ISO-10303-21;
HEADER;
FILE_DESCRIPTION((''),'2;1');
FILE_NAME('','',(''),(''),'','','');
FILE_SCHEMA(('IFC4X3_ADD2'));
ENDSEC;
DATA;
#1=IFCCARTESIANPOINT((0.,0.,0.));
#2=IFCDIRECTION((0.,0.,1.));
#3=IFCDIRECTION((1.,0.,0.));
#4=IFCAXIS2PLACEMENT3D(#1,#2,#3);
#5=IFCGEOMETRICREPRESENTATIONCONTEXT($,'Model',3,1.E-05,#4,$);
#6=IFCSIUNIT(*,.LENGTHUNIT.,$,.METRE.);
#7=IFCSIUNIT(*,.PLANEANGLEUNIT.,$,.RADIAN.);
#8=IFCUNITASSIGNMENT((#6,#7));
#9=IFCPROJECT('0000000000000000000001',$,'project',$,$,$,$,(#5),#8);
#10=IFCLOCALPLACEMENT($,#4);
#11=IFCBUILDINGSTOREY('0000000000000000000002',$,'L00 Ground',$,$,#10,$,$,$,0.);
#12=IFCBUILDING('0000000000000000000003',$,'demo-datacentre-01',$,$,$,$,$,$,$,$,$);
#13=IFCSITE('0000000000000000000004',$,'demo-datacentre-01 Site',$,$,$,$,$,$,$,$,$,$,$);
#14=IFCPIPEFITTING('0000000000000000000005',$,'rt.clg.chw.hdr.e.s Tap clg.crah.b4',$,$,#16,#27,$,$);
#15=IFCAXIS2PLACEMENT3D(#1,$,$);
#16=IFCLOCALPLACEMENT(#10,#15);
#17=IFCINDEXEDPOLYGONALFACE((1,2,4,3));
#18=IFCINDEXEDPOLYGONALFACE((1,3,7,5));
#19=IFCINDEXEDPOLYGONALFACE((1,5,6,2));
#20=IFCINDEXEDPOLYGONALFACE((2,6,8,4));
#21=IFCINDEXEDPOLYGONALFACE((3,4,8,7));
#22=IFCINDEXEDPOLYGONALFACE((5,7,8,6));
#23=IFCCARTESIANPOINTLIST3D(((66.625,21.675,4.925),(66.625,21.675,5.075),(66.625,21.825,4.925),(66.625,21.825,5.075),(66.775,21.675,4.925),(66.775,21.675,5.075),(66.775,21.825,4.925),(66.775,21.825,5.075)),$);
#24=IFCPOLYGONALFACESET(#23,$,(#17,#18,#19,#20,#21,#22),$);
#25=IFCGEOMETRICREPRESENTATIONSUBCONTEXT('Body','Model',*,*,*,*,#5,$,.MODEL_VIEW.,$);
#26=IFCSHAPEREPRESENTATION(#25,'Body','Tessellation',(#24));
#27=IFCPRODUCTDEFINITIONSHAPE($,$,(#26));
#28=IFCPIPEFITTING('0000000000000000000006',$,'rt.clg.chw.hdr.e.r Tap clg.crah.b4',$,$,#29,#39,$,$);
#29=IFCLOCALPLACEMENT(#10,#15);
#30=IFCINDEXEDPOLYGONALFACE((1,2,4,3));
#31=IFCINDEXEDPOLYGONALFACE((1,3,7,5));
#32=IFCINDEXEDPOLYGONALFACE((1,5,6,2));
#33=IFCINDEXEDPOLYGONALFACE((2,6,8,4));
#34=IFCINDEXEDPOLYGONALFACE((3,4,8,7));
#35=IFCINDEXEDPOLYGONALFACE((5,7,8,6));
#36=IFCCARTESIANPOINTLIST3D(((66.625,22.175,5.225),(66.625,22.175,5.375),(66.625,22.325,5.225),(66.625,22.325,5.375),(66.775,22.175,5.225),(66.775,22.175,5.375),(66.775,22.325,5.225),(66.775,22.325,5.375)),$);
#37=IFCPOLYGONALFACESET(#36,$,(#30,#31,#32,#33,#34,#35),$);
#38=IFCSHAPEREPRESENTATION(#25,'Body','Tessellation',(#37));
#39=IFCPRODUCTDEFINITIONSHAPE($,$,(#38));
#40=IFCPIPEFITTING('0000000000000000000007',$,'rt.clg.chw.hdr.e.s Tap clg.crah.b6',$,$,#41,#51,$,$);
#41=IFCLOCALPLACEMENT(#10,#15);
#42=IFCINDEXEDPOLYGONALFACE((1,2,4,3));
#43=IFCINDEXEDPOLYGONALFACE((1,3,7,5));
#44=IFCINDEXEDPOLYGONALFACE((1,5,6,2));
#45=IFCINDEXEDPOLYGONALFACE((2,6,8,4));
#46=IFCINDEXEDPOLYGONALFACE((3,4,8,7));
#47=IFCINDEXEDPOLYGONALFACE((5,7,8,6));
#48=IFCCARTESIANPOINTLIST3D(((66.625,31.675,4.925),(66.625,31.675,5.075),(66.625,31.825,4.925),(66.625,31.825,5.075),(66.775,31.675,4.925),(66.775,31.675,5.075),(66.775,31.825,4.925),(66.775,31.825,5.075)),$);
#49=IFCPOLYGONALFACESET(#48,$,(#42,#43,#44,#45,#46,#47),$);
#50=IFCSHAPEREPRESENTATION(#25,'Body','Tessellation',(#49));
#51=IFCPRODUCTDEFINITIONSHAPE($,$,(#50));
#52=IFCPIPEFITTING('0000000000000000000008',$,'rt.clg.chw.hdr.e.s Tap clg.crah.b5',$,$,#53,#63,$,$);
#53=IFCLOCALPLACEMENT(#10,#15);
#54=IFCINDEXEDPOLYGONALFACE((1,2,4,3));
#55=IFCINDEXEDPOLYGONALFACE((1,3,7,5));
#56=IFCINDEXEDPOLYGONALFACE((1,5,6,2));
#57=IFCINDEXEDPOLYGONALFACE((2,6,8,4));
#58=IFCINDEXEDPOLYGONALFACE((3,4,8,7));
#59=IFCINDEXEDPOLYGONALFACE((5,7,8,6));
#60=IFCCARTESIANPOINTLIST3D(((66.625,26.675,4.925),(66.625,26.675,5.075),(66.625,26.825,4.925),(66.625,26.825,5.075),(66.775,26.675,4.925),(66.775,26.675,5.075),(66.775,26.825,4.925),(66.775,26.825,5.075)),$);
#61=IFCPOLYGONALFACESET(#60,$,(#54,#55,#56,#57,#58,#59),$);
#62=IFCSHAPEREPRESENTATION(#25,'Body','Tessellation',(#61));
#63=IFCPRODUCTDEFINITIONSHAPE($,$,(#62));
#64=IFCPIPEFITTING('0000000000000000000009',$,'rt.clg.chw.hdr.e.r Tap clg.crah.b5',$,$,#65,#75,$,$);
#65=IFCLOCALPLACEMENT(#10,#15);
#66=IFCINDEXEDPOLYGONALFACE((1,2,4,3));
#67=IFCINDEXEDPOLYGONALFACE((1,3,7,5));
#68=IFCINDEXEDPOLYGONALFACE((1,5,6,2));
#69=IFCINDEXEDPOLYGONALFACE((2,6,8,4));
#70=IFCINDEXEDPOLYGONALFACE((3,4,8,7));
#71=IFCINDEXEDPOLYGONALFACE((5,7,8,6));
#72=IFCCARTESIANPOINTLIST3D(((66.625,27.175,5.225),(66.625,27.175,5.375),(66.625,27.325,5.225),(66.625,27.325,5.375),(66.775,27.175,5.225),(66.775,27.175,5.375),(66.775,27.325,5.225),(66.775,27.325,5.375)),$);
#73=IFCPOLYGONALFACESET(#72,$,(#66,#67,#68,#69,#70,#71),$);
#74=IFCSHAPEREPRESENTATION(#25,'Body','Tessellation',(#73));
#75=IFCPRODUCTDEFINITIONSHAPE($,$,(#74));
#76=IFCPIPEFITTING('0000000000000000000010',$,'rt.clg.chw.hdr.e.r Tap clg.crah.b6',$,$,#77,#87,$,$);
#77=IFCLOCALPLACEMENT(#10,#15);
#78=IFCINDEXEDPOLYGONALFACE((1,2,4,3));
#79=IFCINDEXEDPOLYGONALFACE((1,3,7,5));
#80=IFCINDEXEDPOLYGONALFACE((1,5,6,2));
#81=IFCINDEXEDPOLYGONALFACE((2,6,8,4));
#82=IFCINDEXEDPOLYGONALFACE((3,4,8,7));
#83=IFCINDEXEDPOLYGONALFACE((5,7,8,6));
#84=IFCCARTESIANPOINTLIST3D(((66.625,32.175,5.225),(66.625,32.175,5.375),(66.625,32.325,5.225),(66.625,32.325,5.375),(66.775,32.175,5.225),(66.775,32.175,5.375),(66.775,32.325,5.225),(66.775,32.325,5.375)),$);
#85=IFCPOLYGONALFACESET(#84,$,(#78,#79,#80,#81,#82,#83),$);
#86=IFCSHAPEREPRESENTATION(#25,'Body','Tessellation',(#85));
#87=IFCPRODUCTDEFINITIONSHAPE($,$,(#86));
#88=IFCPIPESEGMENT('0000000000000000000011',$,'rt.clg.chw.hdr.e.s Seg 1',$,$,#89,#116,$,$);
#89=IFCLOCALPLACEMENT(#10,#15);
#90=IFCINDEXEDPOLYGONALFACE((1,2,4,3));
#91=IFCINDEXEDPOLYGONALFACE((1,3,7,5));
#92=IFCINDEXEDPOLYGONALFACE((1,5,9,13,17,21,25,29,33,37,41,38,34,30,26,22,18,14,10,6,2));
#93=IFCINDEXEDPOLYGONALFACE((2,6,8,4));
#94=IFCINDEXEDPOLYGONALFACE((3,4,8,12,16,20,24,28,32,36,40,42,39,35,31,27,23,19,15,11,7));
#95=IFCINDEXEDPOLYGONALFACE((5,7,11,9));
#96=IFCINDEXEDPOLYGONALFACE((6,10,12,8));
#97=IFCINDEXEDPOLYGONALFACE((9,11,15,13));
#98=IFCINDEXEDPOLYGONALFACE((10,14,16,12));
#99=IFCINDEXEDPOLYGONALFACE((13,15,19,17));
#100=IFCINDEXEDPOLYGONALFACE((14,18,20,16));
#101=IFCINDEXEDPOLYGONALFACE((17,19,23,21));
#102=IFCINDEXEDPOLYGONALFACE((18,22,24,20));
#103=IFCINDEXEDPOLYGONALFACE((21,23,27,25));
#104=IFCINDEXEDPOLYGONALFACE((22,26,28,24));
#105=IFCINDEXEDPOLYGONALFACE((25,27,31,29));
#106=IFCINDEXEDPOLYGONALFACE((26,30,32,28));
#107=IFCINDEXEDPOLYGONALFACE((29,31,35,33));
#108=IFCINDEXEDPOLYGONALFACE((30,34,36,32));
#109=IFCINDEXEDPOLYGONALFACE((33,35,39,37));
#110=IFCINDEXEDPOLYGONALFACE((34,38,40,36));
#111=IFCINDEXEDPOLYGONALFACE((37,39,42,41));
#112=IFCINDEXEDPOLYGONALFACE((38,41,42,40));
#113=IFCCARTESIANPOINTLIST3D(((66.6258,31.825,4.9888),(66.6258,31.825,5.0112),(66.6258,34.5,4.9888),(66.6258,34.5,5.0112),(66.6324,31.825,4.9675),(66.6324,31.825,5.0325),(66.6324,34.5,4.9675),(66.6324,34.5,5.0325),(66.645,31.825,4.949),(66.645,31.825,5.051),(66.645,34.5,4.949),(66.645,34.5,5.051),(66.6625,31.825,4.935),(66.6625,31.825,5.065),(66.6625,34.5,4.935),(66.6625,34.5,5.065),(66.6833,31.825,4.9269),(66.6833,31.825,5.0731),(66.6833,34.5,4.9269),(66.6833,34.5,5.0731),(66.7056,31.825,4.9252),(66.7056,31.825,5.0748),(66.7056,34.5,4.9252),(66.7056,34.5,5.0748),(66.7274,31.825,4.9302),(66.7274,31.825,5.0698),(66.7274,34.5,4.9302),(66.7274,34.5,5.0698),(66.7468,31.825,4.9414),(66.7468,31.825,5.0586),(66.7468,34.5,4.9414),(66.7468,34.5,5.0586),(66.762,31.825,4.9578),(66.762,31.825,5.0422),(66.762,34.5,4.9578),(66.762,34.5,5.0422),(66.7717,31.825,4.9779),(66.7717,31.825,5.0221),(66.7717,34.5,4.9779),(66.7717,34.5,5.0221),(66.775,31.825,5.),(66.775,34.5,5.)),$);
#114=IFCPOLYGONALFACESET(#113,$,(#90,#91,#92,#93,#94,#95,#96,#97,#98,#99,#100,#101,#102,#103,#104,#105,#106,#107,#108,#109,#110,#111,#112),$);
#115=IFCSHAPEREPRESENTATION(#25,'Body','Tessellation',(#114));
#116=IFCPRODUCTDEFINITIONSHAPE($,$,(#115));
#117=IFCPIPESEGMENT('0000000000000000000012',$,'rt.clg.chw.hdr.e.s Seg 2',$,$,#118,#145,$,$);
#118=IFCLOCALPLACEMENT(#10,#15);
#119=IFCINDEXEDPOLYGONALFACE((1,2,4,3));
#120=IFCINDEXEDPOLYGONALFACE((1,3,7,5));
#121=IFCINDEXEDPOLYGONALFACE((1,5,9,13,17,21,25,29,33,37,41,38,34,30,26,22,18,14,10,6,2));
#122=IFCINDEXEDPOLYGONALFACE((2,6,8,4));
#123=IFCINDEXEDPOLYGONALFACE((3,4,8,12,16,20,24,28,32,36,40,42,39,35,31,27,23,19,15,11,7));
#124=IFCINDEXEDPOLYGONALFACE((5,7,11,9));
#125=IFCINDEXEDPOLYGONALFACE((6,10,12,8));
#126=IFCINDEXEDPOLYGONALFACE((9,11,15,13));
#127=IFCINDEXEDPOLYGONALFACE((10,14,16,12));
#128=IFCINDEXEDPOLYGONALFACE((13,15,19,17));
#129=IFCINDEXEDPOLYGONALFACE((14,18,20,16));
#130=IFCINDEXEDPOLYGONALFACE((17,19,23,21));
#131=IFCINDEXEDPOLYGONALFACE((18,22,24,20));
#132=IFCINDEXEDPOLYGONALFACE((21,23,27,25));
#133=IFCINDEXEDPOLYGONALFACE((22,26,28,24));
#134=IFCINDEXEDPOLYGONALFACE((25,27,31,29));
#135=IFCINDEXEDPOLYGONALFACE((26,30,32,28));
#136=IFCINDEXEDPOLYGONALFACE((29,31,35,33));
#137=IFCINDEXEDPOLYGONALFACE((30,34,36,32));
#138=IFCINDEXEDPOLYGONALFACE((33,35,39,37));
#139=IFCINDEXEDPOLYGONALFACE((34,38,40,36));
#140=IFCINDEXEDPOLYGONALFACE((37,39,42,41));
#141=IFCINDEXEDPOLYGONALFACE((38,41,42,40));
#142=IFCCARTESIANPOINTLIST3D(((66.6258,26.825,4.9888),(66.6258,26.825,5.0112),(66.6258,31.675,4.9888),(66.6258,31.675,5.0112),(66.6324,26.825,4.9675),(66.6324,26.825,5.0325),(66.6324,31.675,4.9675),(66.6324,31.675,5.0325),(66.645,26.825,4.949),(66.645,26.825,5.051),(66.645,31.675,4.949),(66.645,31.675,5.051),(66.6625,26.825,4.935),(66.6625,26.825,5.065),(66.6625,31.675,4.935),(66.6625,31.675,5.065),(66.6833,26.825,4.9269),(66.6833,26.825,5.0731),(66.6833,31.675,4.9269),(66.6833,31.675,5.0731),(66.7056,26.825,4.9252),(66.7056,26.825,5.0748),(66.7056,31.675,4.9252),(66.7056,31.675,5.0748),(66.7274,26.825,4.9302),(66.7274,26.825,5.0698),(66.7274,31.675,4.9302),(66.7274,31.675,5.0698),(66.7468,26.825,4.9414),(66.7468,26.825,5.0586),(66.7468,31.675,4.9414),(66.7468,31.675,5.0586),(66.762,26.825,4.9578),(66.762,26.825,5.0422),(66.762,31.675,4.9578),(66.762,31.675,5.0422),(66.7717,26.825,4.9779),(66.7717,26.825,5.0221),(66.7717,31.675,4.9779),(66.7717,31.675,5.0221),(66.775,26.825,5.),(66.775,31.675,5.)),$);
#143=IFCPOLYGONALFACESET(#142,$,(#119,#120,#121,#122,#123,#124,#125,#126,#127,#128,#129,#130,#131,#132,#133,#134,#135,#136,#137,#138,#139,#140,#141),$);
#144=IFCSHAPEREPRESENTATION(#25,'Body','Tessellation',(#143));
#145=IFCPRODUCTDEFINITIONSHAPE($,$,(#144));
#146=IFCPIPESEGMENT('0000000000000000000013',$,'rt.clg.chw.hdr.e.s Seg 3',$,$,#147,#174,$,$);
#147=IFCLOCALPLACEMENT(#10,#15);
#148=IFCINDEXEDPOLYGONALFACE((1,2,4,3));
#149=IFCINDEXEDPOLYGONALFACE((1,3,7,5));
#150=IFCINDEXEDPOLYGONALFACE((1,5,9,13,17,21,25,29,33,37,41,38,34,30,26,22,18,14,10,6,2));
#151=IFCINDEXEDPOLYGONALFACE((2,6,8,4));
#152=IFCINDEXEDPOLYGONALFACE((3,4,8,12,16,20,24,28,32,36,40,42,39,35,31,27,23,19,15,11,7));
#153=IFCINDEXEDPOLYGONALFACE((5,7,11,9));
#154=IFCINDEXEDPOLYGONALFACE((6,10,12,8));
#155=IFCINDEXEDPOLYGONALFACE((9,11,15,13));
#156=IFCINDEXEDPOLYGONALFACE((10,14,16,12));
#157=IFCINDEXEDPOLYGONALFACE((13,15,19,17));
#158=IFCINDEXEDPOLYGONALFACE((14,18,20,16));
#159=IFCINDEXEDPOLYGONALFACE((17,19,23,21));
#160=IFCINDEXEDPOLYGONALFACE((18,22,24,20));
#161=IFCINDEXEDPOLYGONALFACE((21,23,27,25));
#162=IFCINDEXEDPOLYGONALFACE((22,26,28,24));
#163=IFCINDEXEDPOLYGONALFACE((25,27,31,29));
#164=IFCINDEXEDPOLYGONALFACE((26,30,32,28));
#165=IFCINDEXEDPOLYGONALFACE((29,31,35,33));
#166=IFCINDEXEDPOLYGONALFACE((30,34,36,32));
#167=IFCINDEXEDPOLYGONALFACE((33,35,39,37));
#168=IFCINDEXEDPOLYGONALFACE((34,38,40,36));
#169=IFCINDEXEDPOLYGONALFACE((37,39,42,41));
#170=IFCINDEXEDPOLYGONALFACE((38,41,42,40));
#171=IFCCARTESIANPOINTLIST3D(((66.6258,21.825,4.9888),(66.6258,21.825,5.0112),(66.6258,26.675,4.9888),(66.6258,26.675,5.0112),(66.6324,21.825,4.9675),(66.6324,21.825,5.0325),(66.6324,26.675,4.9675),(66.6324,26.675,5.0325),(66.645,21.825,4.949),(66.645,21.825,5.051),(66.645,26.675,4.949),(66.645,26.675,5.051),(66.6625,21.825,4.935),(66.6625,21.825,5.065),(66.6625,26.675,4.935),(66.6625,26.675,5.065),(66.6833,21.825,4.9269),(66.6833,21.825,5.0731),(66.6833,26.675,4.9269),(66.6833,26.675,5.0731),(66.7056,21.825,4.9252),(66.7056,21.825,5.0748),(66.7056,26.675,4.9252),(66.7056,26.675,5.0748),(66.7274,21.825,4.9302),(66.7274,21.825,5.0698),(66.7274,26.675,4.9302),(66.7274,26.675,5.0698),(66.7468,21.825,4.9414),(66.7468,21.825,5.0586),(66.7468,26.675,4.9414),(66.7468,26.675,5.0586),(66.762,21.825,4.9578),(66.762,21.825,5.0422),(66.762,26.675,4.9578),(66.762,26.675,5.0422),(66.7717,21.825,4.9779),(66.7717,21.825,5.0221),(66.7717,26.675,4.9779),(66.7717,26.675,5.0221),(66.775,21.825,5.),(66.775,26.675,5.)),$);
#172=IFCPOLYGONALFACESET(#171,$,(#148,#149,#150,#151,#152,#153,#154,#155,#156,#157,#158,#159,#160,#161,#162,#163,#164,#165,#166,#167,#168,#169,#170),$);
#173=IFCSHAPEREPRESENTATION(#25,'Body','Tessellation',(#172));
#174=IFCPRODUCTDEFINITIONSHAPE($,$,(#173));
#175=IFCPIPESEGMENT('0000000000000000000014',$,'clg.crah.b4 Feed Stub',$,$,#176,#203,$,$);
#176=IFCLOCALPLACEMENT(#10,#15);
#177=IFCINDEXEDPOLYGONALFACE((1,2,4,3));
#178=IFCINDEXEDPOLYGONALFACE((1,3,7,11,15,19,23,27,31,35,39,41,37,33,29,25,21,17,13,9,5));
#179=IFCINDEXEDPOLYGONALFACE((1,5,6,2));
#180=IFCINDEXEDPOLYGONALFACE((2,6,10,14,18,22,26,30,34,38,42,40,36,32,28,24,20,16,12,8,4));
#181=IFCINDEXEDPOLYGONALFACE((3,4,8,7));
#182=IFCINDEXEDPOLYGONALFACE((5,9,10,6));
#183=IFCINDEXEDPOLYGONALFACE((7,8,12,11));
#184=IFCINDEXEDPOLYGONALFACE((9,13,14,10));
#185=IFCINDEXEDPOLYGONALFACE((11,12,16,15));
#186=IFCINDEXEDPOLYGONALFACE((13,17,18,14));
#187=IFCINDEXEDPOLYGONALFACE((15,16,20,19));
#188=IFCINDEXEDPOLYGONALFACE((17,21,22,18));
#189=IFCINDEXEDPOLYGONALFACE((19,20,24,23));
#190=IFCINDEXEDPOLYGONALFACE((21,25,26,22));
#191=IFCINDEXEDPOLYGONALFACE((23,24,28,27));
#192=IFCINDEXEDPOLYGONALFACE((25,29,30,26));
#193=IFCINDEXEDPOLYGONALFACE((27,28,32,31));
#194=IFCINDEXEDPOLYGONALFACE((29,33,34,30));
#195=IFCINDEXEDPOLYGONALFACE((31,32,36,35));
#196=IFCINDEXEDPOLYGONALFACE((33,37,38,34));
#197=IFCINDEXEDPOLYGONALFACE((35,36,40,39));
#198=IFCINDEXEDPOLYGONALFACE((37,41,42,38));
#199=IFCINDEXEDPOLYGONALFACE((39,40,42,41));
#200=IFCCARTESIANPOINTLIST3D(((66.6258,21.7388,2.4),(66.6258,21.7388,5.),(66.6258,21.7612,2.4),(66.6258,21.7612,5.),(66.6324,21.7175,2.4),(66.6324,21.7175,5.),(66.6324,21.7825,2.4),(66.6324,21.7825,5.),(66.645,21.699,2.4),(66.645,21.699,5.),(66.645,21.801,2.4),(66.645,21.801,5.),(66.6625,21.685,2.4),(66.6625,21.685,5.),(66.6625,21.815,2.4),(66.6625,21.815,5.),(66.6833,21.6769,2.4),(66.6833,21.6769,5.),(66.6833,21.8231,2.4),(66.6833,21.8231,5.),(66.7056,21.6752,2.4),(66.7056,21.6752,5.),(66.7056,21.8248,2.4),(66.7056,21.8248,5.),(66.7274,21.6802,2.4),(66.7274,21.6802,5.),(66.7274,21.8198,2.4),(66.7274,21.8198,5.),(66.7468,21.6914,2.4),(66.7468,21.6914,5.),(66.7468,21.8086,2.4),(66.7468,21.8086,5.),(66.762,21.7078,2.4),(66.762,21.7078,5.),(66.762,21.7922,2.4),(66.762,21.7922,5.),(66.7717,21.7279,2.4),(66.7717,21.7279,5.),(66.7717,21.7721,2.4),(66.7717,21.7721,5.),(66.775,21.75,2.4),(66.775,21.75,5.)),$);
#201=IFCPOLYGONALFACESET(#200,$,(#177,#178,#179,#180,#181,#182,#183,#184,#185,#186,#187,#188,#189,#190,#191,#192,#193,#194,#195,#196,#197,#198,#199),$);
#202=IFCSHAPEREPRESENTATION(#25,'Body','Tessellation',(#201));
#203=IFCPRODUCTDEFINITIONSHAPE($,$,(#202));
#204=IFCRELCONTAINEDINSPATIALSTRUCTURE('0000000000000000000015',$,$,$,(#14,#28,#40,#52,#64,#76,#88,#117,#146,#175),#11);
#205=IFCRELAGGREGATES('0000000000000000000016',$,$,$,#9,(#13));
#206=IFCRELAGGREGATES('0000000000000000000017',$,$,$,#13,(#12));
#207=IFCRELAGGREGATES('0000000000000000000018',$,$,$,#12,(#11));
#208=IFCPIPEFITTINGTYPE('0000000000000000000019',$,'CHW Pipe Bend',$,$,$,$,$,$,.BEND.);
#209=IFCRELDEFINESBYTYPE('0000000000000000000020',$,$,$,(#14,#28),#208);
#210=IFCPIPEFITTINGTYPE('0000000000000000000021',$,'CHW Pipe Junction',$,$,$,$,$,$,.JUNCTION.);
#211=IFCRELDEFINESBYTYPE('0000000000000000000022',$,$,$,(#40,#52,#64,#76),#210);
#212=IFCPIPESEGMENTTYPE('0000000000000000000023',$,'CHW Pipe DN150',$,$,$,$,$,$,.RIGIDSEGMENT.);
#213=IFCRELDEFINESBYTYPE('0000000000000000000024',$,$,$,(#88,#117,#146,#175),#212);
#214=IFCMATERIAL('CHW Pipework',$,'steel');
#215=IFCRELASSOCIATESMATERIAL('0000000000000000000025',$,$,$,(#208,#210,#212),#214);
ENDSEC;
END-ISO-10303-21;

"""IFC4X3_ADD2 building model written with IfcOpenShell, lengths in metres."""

from ifc_helpers import new_model, si_unit, frame, origin_with_axes, place, context, subcontext, project, spatial, rectangle, circle, extrude, material, type_object, element, save


model = new_model("IFC4X3_ADD2")

# Units and contexts
model_context = context("Model", 3, precision=1e-05, world=origin_with_axes())
body_context = subcontext(model_context, "Body", "Model", "MODEL_VIEW")
ifc_project = project(units=[si_unit("LENGTHUNIT", "METRE"), si_unit("PLANEANGLEUNIT", "RADIAN")], contexts=[model_context])

# Site, building, storey
site = spatial("IfcSite", under=ifc_project, Name="demo-datacentre-01 Site")
building = spatial("IfcBuilding", under=site, Name="demo-datacentre-01")
storey_placement = place(None, origin_with_axes())
storey = spatial("IfcBuildingStorey", under=building, at=storey_placement, Name="L00 Ground", Elevation=0.0)

# Pipe fittings
ifc_material = material(Name="CHW Pipework", Category="steel")
pipe_fitting_type_1 = type_object("IfcPipeFittingType", Name="CHW Pipe Bend", PredefinedType="BEND", material=ifc_material)
for number, where, z_axis, x_axis, name in (
    (1, (66.7, 21.75, 4.925), (0.0, 0.0, 1.0), (1.0, 0.0, 0.0), "rt.clg.chw.hdr.e.s Tap clg.crah.b4"),
    (2, (66.7, 22.25, 5.225), (0.0, 0.0, 1.0), (1.0, 0.0, 0.0), "rt.clg.chw.hdr.e.r Tap clg.crah.b4"),
):
    element("IfcPipeFitting", number, at=place(storey_placement, frame(where, z_axis=z_axis, x_axis=x_axis)), inside=storey, type_object=pipe_fitting_type_1, Name=name, context=body_context, shape_type="SweptSolid", body=[
        extrude(rectangle(XDim=0.15, YDim=0.15), origin_with_axes(), (0.0, 0.0, 1.0), 0.15),
    ])
pipe_fitting_type_2 = type_object("IfcPipeFittingType", Name="CHW Pipe Junction", PredefinedType="JUNCTION", material=ifc_material)
for number, where, z_axis, x_axis, name in (
    (3, (66.7, 31.75, 4.925), (0.0, 0.0, 1.0), (1.0, 0.0, 0.0), "rt.clg.chw.hdr.e.s Tap clg.crah.b6"),
    (4, (66.7, 26.75, 4.925), (0.0, 0.0, 1.0), (1.0, 0.0, 0.0), "rt.clg.chw.hdr.e.s Tap clg.crah.b5"),
    (5, (66.7, 27.25, 5.225), (0.0, 0.0, 1.0), (1.0, 0.0, 0.0), "rt.clg.chw.hdr.e.r Tap clg.crah.b5"),
    (6, (66.7, 32.25, 5.225), (0.0, 0.0, 1.0), (1.0, 0.0, 0.0), "rt.clg.chw.hdr.e.r Tap clg.crah.b6"),
):
    element("IfcPipeFitting", number, at=place(storey_placement, frame(where, z_axis=z_axis, x_axis=x_axis)), inside=storey, type_object=pipe_fitting_type_2, Name=name, context=body_context, shape_type="SweptSolid", body=[
        extrude(rectangle(XDim=0.15, YDim=0.15), origin_with_axes(), (0.0, 0.0, 1.0), 0.15),
    ])

# Pipe segments
pipe_segment_type_1 = type_object("IfcPipeSegmentType", Name="CHW Pipe DN150", PredefinedType="RIGIDSEGMENT", material=ifc_material)
pipe_segment_1_placement = place(storey_placement, frame((66.7, 34.5, 5.0), z_axis=(0.0, -1.0, 0.0), x_axis=(1.0, 0.0, 0.0)))
element("IfcPipeSegment", 7, at=pipe_segment_1_placement, inside=storey, type_object=pipe_segment_type_1, Name="rt.clg.chw.hdr.e.s Seg 1", context=body_context, shape_type="SweptSolid", body=[
    extrude(circle(Radius=0.075), origin_with_axes(), (0.0, 0.0, 1.0), 2.675),
])
for number, where, z_axis, x_axis, name in (
    (8, (66.7, 31.675, 5.0), (0.0, -1.0, 0.0), (1.0, 0.0, 0.0), "rt.clg.chw.hdr.e.s Seg 2"),
    (9, (66.7, 26.675, 5.0), (0.0, -1.0, 0.0), (1.0, 0.0, 0.0), "rt.clg.chw.hdr.e.s Seg 3"),
):
    element("IfcPipeSegment", number, at=place(storey_placement, frame(where, z_axis=z_axis, x_axis=x_axis)), inside=storey, type_object=pipe_segment_type_1, Name=name, context=body_context, shape_type="SweptSolid", body=[
        extrude(circle(Radius=0.075), origin_with_axes(), (0.0, 0.0, 1.0), 4.85),
    ])
for number, where, z_axis, x_axis, name in (
    (10, (66.7, 21.75, 5.0), (0.0, 0.0, -1.0), (1.0, 0.0, 0.0), "clg.crah.b4 Feed Stub"),
):
    element("IfcPipeSegment", number, at=place(storey_placement, frame(where, z_axis=z_axis, x_axis=x_axis)), inside=storey, type_object=pipe_segment_type_1, Name=name, context=body_context, shape_type="SweptSolid", body=[
        extrude(circle(Radius=0.075), origin_with_axes(), (0.0, 0.0, 1.0), 2.6),
    ])

save(model, "model.ifc")
